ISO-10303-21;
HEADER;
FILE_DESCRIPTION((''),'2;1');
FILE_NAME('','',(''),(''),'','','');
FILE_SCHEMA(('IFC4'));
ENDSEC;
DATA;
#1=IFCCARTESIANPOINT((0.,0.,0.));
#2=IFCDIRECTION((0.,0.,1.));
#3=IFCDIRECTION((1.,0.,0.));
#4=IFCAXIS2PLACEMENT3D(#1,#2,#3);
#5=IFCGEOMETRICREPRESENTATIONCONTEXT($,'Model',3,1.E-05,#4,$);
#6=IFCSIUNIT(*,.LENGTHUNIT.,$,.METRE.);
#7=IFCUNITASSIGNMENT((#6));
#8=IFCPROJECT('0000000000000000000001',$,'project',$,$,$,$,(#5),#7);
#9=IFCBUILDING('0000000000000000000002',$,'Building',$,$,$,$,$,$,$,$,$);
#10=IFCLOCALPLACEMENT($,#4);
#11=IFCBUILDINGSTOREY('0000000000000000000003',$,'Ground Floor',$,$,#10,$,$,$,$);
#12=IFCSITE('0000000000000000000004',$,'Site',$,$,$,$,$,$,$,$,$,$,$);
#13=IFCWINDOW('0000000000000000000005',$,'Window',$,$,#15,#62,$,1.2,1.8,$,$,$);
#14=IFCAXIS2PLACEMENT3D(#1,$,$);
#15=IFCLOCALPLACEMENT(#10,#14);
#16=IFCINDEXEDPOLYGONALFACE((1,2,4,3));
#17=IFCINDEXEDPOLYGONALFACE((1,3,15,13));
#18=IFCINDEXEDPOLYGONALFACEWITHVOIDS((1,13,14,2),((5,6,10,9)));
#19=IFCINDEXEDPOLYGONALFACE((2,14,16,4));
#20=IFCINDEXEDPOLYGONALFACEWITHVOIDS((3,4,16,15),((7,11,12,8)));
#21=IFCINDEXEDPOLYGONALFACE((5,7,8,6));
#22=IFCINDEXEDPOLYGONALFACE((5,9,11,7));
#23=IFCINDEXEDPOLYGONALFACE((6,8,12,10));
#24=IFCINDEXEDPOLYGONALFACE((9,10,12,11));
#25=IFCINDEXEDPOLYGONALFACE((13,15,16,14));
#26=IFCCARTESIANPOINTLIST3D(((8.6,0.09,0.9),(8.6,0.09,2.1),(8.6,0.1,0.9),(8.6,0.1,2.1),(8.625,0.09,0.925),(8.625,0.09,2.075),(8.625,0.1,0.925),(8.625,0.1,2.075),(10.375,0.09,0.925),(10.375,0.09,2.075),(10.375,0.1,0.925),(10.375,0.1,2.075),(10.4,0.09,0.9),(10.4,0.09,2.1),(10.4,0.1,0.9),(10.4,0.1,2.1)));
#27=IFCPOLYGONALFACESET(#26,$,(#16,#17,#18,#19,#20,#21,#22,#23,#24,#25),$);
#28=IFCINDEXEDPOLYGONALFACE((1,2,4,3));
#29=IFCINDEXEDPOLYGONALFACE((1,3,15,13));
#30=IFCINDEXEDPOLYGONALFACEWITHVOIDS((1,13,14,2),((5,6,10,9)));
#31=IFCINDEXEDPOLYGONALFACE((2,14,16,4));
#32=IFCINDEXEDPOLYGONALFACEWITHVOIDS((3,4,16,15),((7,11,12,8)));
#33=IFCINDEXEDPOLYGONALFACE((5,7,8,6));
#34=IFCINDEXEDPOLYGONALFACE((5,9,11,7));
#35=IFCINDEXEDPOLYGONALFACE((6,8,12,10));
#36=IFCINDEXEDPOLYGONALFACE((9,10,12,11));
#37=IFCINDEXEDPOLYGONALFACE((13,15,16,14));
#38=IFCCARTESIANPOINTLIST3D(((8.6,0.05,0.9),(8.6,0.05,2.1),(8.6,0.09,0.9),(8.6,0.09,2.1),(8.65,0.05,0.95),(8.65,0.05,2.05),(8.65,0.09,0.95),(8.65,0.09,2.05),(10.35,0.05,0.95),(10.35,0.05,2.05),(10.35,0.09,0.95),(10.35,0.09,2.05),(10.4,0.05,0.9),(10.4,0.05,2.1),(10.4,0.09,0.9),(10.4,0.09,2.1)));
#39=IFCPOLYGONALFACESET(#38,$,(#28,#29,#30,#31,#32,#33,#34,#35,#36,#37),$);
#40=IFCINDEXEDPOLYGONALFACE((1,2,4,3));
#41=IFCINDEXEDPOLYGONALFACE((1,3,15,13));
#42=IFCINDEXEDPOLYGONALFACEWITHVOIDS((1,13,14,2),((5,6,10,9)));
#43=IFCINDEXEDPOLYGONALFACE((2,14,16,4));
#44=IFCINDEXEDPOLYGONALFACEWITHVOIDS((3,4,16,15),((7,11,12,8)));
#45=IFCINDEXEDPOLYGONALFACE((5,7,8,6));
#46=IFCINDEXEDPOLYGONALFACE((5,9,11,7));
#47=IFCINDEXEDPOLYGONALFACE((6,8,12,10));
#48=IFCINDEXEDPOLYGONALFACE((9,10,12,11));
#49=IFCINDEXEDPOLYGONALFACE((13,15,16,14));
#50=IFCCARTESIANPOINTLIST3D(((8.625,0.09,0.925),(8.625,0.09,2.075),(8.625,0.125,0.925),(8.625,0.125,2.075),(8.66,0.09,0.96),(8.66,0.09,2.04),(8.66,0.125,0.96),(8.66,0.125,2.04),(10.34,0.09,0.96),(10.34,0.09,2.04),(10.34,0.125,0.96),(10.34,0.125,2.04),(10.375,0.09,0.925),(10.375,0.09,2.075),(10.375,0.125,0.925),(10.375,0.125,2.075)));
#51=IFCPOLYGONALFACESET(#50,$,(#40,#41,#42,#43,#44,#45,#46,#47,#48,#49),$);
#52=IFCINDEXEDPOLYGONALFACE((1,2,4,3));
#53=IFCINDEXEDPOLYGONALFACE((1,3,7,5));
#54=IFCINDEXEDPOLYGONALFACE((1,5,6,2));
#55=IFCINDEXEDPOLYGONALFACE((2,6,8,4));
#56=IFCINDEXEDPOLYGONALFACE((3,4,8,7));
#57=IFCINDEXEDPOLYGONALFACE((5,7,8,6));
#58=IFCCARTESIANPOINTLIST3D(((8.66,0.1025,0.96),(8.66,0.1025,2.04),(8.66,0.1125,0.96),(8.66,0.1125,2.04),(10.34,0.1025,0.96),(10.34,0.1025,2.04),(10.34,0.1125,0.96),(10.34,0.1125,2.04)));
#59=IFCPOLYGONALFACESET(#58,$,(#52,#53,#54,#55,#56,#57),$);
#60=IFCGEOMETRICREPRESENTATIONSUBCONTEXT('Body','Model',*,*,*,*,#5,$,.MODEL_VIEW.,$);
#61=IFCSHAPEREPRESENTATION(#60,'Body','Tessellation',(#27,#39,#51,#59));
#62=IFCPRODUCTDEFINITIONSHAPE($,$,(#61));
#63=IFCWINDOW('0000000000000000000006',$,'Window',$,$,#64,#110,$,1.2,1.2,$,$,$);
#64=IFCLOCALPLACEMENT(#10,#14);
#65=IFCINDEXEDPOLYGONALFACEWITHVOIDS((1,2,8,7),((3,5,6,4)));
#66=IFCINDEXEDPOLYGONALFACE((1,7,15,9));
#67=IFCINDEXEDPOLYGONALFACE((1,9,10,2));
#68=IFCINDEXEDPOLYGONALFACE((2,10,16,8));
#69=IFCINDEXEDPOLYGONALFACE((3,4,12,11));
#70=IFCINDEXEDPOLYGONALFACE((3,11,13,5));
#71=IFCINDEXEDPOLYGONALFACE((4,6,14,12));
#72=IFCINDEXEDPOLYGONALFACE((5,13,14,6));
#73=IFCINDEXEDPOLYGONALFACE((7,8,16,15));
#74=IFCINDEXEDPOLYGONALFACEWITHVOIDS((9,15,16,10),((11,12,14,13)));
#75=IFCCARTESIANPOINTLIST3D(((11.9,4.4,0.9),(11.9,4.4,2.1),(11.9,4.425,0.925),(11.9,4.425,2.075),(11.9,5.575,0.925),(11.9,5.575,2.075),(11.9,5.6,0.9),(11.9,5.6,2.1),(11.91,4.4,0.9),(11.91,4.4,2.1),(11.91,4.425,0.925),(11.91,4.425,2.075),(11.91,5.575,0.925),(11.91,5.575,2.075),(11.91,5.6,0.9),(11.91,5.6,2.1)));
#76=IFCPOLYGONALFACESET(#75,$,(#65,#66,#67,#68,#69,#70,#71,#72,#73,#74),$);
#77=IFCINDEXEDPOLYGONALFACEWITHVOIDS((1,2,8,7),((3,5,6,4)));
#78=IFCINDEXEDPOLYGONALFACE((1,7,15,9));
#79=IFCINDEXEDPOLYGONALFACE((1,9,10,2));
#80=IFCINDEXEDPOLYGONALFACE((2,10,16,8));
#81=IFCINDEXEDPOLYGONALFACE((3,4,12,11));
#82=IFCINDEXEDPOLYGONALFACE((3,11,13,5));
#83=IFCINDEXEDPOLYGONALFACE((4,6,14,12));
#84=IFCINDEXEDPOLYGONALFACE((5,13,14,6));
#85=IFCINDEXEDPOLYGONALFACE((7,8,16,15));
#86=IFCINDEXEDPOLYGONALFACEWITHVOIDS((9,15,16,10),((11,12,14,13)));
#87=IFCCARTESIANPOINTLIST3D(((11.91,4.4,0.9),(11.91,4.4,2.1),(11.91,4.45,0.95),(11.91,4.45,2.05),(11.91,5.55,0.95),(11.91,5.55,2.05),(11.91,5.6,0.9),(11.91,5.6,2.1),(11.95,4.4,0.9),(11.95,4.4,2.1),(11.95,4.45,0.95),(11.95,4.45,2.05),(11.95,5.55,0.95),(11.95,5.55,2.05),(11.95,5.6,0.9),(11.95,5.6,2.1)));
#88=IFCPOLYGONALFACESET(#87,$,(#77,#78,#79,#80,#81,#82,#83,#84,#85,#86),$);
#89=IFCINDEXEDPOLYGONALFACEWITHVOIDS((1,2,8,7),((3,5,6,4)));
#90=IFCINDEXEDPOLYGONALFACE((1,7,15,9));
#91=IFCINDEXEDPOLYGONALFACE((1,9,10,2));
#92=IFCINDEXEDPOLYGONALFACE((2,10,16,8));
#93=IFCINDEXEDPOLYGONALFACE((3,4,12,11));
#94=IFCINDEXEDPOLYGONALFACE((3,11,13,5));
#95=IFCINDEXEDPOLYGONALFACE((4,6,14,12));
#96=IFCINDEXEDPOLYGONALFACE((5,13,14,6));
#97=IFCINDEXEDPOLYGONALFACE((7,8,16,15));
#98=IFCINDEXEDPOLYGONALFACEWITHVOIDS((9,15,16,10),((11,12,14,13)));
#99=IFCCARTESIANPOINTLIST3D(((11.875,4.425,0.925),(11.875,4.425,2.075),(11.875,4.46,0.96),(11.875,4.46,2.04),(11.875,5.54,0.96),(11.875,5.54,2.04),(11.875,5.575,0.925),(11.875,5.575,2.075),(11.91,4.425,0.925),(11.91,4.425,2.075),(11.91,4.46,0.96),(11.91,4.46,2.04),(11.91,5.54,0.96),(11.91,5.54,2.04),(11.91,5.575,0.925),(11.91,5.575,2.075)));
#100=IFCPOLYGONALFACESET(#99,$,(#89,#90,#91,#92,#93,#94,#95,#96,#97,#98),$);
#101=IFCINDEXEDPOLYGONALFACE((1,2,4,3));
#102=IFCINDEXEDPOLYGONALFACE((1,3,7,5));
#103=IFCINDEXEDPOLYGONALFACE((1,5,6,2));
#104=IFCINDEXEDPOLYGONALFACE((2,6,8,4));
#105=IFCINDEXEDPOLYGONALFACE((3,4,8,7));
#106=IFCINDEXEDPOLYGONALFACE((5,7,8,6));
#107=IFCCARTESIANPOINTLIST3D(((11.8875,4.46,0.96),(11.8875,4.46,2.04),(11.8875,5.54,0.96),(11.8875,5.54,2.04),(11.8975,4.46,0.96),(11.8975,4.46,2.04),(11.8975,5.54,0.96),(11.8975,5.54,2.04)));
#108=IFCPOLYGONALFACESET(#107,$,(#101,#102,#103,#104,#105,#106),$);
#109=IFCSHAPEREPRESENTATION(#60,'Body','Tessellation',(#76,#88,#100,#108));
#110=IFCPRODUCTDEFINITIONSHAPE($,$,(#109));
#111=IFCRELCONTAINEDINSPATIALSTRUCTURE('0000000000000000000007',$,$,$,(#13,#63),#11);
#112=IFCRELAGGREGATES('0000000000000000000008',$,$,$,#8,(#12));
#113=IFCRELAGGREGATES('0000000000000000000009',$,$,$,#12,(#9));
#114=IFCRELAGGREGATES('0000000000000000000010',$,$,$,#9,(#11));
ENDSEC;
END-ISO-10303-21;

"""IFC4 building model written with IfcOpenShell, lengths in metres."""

from ifc_helpers import new_model, si_unit, frame, origin_with_axes, place, context, subcontext, project, spatial, line, indexed_curve, outline, extrude, element, save


model = new_model("IFC4")

# Units and contexts
model_context = context("Model", 3, precision=1e-05, world=origin_with_axes())
body_context = subcontext(model_context, "Body", "Model", "MODEL_VIEW")
ifc_project = project(units=[si_unit("LENGTHUNIT", "METRE")], contexts=[model_context])

# Site, building, storey
site = spatial("IfcSite", under=ifc_project, Name="Site")
building = spatial("IfcBuilding", under=site, Name="Building")
storey_placement = place(None, origin_with_axes())
storey = spatial("IfcBuildingStorey", under=building, at=storey_placement, Name="Ground Floor")

# Windows
window_1_placement = place(storey_placement, frame((8.6, 0.0, 0.9), z_axis=(0.0, 0.0, 1.0), x_axis=(1.0, 0.0, 0.0)))
element("IfcWindow", 1, at=window_1_placement, inside=storey, Name="Window", OverallHeight=1.2, OverallWidth=1.8, context=body_context, shape_type="SweptSolid", body=[
    extrude(outline(indexed_curve([(0.0, 0.0), (1.8, 0.0), (1.8, 1.2), (0.0, 1.2)], segments=[line(1, 2, 3, 4, 1)]), holes=[indexed_curve([(0.025, 0.025), (1.775, 0.025), (1.775, 1.175), (0.025, 1.175)], segments=[line(1, 2, 3, 4, 1)])]), frame((0.0, 0.09, 0.0), z_axis=(0.0, -1.0, 0.0), x_axis=(1.0, 0.0, 0.0)), (0.0, 0.0, -1.0), 0.01),
    extrude(outline(indexed_curve([(0.0, 0.0), (1.8, 0.0), (1.8, 1.2), (0.0, 1.2)], segments=[line(1, 2, 3, 4, 1)]), holes=[indexed_curve([(0.05, 0.05), (1.75, 0.05), (1.75, 1.15), (0.05, 1.15)], segments=[line(1, 2, 3, 4, 1)])]), frame((0.0, 0.05, 0.0), z_axis=(0.0, -1.0, 0.0), x_axis=(1.0, 0.0, 0.0)), (0.0, 0.0, -1.0), 0.04),
    extrude(outline(indexed_curve([(0.0, 0.0), (1.75, 0.0), (1.75, 1.15), (0.0, 1.15)], segments=[line(1, 2, 3, 4, 1)]), holes=[indexed_curve([(0.035, 0.035), (1.715, 0.035), (1.715, 1.115), (0.035, 1.115)], segments=[line(1, 2, 3, 4, 1)])]), frame((0.025, 0.09, 0.025), z_axis=(0.0, -1.0, 0.0), x_axis=(1.0, 0.0, 0.0)), (0.0, 0.0, -1.0), 0.035),
    extrude(outline(indexed_curve([(0.035, 0.035), (1.715, 0.035), (1.715, 1.115), (0.035, 1.115)], segments=[line(1, 2, 3, 4, 1)])), frame((0.025, 0.1025, 0.025), z_axis=(0.0, -1.0, 0.0), x_axis=(1.0, 0.0, 0.0)), (0.0, 0.0, -1.0), 0.01),
])
window_2_placement = place(storey_placement, frame((12.0, 4.4, 0.9), z_axis=(0.0, 0.0, 1.0), x_axis=(0.0, 1.0, 0.0)))
element("IfcWindow", 2, at=window_2_placement, inside=storey, Name="Window", OverallHeight=1.2, OverallWidth=1.2, context=body_context, shape_type="SweptSolid", body=[
    extrude(outline(indexed_curve([(0.0, 0.0), (1.2, 0.0), (1.2, 1.2), (0.0, 1.2)], segments=[line(1, 2, 3, 4, 1)]), holes=[indexed_curve([(0.025, 0.025), (1.175, 0.025), (1.175, 1.175), (0.025, 1.175)], segments=[line(1, 2, 3, 4, 1)])]), frame((0.0, 0.09, 0.0), z_axis=(0.0, -1.0, 0.0), x_axis=(1.0, 0.0, 0.0)), (0.0, 0.0, -1.0), 0.01),
    extrude(outline(indexed_curve([(0.0, 0.0), (1.2, 0.0), (1.2, 1.2), (0.0, 1.2)], segments=[line(1, 2, 3, 4, 1)]), holes=[indexed_curve([(0.05, 0.05), (1.15, 0.05), (1.15, 1.15), (0.05, 1.15)], segments=[line(1, 2, 3, 4, 1)])]), frame((0.0, 0.05, 0.0), z_axis=(0.0, -1.0, 0.0), x_axis=(1.0, 0.0, 0.0)), (0.0, 0.0, -1.0), 0.04),
    extrude(outline(indexed_curve([(0.0, 0.0), (1.15, 0.0), (1.15, 1.15), (0.0, 1.15)], segments=[line(1, 2, 3, 4, 1)]), holes=[indexed_curve([(0.035, 0.035), (1.115, 0.035), (1.115, 1.115), (0.035, 1.115)], segments=[line(1, 2, 3, 4, 1)])]), frame((0.025, 0.09, 0.025), z_axis=(0.0, -1.0, 0.0), x_axis=(1.0, 0.0, 0.0)), (0.0, 0.0, -1.0), 0.035),
    extrude(outline(indexed_curve([(0.035, 0.035), (1.115, 0.035), (1.115, 1.115), (0.035, 1.115)], segments=[line(1, 2, 3, 4, 1)])), frame((0.025, 0.1025, 0.025), z_axis=(0.0, -1.0, 0.0), x_axis=(1.0, 0.0, 0.0)), (0.0, 0.0, -1.0), 0.01),
])

save(model, "model.ifc")
